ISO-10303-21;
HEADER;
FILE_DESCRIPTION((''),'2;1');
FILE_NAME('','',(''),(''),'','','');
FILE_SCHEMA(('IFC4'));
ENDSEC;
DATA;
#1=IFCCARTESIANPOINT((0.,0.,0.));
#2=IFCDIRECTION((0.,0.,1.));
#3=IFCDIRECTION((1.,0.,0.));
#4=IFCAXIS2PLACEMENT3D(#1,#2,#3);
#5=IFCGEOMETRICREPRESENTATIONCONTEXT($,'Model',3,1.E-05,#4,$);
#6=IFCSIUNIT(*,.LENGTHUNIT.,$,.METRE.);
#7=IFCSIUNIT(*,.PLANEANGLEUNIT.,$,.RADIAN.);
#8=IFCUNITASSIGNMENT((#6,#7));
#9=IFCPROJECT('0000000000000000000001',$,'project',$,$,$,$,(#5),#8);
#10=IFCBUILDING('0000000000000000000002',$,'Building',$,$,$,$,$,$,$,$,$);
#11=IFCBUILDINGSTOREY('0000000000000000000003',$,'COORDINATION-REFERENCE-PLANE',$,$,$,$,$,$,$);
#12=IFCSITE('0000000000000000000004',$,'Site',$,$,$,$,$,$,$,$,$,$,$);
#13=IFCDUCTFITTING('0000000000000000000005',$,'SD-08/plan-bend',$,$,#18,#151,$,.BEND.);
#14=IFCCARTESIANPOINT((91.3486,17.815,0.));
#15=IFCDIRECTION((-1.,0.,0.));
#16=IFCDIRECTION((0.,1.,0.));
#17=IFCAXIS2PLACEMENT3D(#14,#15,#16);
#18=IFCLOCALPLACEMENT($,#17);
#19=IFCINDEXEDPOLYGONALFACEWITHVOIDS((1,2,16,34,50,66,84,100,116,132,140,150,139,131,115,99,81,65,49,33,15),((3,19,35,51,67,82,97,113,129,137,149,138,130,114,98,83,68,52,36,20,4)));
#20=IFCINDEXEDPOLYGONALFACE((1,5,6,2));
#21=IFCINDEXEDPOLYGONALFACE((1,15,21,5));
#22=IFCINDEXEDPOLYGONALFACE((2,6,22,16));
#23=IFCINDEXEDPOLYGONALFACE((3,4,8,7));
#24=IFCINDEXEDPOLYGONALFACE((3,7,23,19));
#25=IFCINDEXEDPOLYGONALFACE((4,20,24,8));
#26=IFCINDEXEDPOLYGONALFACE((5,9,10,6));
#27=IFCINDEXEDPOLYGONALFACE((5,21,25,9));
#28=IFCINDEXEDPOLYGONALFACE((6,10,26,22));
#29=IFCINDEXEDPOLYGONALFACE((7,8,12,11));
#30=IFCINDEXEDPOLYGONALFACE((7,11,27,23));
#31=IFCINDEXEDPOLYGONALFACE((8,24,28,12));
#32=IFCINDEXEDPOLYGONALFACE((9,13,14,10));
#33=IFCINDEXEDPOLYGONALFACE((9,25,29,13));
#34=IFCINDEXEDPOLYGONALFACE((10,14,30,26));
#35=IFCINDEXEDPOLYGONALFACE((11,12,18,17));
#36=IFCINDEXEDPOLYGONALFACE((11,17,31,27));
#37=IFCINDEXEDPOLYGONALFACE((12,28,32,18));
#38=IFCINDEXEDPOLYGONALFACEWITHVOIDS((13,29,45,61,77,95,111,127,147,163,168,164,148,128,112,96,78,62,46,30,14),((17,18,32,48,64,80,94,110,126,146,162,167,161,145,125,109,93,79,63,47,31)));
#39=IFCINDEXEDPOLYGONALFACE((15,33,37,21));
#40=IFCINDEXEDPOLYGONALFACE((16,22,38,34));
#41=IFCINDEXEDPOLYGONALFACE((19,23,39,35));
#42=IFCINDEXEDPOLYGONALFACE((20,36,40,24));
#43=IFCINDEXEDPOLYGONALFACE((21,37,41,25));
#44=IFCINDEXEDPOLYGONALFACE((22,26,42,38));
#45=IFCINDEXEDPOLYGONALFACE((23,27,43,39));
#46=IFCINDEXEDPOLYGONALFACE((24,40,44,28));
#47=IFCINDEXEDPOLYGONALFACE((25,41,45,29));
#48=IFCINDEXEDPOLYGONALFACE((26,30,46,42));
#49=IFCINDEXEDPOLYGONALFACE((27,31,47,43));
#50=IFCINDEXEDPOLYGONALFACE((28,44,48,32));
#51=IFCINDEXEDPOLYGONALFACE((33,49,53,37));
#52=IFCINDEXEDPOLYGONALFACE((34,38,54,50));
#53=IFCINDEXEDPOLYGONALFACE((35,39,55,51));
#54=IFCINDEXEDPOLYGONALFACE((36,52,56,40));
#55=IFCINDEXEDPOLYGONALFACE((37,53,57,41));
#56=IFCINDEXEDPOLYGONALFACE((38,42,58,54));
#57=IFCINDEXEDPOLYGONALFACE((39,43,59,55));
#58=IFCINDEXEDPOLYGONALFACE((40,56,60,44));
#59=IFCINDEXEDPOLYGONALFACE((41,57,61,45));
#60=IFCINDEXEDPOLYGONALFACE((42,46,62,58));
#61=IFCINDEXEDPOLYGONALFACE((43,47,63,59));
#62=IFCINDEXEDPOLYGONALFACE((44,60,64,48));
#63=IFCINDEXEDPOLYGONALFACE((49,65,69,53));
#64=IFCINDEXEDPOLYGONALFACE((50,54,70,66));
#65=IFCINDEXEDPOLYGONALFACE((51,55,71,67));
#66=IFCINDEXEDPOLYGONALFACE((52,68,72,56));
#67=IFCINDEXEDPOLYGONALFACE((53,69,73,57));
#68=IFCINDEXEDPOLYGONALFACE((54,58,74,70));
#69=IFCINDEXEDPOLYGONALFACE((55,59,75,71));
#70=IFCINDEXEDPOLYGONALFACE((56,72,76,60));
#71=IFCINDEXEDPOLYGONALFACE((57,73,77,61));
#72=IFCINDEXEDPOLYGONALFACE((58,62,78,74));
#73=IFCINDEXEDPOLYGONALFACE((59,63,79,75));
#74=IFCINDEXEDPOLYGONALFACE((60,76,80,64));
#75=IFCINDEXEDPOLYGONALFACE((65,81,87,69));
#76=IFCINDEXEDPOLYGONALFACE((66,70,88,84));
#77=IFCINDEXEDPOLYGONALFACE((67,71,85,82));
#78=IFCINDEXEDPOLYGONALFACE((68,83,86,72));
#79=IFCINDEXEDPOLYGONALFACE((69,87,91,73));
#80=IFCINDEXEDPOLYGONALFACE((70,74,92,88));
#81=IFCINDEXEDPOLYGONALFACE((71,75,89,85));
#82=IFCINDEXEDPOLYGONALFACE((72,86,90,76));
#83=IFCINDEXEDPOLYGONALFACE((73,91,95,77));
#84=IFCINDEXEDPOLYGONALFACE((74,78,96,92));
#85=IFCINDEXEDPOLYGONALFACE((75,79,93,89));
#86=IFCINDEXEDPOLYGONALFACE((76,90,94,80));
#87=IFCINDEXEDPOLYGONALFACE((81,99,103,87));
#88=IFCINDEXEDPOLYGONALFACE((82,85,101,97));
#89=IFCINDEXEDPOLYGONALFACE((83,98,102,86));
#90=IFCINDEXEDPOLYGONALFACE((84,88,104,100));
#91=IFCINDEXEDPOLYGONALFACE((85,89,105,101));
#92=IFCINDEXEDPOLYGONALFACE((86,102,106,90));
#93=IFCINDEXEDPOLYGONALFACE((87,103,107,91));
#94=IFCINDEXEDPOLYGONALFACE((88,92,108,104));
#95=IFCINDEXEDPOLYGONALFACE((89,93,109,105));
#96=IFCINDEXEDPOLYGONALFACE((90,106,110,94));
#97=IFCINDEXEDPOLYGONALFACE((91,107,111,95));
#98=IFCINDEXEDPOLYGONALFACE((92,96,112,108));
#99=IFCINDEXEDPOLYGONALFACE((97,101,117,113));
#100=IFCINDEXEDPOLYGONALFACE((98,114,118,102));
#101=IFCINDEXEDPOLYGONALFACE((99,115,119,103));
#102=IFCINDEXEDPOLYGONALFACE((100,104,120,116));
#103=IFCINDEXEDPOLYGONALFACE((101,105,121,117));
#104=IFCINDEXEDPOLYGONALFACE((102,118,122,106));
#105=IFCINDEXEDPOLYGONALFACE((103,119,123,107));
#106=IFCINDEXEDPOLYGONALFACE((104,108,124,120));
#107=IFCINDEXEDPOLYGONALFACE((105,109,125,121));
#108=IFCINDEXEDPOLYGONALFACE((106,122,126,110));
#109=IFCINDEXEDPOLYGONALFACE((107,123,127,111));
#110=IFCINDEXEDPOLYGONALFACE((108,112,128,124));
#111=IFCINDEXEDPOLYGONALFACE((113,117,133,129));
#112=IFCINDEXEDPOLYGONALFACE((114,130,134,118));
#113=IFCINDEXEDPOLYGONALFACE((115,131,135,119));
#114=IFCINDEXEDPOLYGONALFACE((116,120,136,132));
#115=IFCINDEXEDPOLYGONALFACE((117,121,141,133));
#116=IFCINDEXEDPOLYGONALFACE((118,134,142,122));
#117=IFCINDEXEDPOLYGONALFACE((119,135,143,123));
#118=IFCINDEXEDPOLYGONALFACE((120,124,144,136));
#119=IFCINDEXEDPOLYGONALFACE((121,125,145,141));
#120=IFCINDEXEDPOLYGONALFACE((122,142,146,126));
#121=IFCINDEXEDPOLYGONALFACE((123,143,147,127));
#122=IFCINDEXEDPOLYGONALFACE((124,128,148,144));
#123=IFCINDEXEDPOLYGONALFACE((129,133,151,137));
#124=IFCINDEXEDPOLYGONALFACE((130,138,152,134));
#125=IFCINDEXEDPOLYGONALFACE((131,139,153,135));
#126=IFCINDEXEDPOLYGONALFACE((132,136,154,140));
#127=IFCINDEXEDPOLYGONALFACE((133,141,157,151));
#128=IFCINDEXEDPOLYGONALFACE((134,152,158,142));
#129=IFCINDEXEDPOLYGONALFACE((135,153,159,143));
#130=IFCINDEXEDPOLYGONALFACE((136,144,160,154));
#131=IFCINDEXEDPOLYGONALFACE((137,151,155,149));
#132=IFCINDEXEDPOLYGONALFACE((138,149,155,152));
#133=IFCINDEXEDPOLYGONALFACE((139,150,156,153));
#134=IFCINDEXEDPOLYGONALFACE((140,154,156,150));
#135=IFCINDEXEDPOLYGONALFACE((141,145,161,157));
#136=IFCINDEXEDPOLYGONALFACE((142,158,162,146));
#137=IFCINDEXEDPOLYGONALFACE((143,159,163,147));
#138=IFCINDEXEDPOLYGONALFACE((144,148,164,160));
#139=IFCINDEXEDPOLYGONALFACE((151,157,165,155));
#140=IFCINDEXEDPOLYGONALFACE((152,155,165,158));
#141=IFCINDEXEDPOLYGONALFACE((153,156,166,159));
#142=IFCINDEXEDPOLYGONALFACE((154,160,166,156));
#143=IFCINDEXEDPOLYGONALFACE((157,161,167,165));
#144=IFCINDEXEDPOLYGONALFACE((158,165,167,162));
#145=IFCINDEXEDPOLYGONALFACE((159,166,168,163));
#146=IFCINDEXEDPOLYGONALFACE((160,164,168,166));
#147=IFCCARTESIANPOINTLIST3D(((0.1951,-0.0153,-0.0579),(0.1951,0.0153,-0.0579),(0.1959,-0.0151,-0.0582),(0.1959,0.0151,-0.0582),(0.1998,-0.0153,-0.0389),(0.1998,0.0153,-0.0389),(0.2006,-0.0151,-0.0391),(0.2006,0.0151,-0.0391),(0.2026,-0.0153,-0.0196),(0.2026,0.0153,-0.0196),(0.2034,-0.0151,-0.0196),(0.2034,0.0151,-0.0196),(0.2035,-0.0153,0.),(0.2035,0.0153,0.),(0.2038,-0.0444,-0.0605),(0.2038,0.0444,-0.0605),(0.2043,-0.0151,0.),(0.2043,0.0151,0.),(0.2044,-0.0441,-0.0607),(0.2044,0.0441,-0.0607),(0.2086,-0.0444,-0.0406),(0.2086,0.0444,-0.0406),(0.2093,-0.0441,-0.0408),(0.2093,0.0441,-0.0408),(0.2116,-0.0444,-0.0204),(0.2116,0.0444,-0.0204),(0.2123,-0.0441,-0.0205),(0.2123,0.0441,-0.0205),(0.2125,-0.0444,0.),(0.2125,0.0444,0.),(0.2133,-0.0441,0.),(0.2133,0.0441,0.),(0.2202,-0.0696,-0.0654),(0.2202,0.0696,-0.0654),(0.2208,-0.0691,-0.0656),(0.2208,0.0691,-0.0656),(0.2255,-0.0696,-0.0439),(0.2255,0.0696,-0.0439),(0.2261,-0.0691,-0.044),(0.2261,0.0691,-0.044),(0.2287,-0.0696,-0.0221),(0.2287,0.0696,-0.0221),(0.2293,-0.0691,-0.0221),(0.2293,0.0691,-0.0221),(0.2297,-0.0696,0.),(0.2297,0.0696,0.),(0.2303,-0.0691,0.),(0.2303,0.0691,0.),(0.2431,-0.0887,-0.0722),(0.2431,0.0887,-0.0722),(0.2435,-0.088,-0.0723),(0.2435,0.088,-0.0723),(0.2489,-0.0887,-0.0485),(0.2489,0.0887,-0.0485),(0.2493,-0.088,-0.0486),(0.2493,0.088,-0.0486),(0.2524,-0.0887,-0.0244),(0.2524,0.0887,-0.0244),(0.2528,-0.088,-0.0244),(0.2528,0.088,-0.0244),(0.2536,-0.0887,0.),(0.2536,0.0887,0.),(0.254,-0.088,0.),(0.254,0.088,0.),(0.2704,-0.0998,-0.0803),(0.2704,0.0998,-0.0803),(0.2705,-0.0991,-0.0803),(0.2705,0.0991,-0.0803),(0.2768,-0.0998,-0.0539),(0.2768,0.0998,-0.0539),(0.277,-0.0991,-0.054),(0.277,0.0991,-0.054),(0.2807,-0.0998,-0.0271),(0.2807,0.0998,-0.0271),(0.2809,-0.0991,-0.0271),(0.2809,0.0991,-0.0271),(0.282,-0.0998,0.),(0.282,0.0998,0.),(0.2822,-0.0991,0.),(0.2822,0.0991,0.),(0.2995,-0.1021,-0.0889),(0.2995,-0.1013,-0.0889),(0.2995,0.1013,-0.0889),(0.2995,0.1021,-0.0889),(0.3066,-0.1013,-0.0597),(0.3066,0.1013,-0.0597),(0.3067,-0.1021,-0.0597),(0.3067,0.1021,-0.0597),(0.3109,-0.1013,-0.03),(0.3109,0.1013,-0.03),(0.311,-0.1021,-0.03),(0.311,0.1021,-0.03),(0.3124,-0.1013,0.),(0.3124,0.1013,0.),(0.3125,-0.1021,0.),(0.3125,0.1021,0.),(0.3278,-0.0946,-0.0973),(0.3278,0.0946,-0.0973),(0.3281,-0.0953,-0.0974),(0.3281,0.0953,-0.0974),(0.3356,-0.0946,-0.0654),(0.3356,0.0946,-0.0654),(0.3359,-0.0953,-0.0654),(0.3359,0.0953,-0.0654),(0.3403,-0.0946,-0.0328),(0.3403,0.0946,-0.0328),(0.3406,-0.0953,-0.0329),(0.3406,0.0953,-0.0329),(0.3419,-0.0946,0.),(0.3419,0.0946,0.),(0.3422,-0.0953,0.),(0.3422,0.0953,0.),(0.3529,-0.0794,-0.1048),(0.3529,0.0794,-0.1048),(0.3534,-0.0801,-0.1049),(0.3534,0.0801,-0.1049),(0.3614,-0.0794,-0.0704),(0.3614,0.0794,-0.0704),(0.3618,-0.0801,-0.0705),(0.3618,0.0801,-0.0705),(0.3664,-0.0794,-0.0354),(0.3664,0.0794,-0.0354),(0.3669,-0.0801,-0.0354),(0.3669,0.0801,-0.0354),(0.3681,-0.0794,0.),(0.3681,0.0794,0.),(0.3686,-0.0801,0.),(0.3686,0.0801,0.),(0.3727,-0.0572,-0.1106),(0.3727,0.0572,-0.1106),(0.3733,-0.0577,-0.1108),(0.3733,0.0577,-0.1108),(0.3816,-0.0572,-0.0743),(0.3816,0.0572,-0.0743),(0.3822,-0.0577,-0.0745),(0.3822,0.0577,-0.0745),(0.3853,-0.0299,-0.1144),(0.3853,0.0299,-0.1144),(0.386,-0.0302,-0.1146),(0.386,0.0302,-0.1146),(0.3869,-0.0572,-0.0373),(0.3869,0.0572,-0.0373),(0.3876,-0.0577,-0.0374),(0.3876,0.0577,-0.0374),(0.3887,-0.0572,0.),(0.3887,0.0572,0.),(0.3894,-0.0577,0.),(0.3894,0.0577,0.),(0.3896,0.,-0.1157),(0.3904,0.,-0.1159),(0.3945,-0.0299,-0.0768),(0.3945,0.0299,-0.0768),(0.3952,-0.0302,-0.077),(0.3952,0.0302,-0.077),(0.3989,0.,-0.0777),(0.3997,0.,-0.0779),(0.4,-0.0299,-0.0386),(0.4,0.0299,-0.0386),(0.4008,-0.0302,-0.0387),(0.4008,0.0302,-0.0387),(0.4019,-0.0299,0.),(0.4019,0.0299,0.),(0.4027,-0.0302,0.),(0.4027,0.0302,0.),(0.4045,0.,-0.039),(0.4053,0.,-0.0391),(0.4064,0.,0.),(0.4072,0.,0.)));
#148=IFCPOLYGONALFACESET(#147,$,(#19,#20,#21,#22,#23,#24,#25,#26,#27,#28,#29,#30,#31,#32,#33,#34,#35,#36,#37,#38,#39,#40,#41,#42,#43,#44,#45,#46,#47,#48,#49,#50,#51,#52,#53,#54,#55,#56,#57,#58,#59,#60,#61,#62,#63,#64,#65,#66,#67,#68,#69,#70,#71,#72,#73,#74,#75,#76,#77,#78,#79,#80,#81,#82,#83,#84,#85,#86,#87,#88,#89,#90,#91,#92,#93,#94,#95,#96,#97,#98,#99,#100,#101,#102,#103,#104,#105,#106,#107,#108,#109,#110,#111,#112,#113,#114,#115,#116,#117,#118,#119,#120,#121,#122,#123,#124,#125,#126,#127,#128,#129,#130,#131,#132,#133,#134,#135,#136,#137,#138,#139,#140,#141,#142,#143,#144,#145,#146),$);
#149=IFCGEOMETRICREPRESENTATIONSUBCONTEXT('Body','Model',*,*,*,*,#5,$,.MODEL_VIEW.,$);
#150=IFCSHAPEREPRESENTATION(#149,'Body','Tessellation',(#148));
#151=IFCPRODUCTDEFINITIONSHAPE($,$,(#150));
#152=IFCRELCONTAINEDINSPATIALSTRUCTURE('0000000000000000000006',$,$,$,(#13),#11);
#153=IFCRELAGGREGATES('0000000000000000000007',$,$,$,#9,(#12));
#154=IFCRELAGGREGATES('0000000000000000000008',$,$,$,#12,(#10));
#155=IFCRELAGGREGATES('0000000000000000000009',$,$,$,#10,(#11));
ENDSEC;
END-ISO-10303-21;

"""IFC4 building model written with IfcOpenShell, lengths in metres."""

from ifc_helpers import new_model, entity, si_unit, frame, origin_with_axes, place, context, subcontext, project, spatial, element, save


model = new_model("IFC4")

# Units and contexts
model_context = context("Model", 3, precision=1e-05, world=origin_with_axes())
body_context_1 = subcontext(model_context, "Body", "Model", "MODEL_VIEW")
ifc_project = project(units=[si_unit("LENGTHUNIT", "METRE"), si_unit("PLANEANGLEUNIT", "RADIAN")], contexts=[model_context])

# Site, building, storey
site = spatial("IfcSite", under=ifc_project, Name="Site")
building = spatial("IfcBuilding", under=site, Name="Building")
storey = spatial("IfcBuildingStorey", under=building, Name="COORDINATION-REFERENCE-PLANE")

# Duct fitting
duct_fitting_1_placement = place(None, frame((91.3486, 17.815, 0.0), z_axis=(-1.0, 0.0, 0.0), x_axis=(0.0, 1.0, 0.0)))
element("IfcDuctFitting", 1, at=duct_fitting_1_placement, inside=storey, Name="SD-08/plan-bend", PredefinedType="BEND", context=body_context_1, shape_type="SweptSolid", body=[
    entity("IfcRevolvedAreaSolid", entity("IfcCircleHollowProfileDef", "AREA", None, entity("IfcAxis2Placement2D", entity("IfcCartesianPoint", [0.3048, 0.0])), 0.1024, 0.0008), entity("IfcAxis2Placement3D", entity("IfcCartesianPoint", [0.0, 0.0, 0.0]), entity("IfcDirection", [0.0, 0.0, 1.0]), entity("IfcDirection", [1.0, 0.0, 0.0])), entity("IfcAxis1Placement", entity("IfcCartesianPoint", [0.0, 0.0, 0.0]), entity("IfcDirection", [0.0, 1.0, 0.0])), 0.288593),
])

save(model, "model.ifc")
